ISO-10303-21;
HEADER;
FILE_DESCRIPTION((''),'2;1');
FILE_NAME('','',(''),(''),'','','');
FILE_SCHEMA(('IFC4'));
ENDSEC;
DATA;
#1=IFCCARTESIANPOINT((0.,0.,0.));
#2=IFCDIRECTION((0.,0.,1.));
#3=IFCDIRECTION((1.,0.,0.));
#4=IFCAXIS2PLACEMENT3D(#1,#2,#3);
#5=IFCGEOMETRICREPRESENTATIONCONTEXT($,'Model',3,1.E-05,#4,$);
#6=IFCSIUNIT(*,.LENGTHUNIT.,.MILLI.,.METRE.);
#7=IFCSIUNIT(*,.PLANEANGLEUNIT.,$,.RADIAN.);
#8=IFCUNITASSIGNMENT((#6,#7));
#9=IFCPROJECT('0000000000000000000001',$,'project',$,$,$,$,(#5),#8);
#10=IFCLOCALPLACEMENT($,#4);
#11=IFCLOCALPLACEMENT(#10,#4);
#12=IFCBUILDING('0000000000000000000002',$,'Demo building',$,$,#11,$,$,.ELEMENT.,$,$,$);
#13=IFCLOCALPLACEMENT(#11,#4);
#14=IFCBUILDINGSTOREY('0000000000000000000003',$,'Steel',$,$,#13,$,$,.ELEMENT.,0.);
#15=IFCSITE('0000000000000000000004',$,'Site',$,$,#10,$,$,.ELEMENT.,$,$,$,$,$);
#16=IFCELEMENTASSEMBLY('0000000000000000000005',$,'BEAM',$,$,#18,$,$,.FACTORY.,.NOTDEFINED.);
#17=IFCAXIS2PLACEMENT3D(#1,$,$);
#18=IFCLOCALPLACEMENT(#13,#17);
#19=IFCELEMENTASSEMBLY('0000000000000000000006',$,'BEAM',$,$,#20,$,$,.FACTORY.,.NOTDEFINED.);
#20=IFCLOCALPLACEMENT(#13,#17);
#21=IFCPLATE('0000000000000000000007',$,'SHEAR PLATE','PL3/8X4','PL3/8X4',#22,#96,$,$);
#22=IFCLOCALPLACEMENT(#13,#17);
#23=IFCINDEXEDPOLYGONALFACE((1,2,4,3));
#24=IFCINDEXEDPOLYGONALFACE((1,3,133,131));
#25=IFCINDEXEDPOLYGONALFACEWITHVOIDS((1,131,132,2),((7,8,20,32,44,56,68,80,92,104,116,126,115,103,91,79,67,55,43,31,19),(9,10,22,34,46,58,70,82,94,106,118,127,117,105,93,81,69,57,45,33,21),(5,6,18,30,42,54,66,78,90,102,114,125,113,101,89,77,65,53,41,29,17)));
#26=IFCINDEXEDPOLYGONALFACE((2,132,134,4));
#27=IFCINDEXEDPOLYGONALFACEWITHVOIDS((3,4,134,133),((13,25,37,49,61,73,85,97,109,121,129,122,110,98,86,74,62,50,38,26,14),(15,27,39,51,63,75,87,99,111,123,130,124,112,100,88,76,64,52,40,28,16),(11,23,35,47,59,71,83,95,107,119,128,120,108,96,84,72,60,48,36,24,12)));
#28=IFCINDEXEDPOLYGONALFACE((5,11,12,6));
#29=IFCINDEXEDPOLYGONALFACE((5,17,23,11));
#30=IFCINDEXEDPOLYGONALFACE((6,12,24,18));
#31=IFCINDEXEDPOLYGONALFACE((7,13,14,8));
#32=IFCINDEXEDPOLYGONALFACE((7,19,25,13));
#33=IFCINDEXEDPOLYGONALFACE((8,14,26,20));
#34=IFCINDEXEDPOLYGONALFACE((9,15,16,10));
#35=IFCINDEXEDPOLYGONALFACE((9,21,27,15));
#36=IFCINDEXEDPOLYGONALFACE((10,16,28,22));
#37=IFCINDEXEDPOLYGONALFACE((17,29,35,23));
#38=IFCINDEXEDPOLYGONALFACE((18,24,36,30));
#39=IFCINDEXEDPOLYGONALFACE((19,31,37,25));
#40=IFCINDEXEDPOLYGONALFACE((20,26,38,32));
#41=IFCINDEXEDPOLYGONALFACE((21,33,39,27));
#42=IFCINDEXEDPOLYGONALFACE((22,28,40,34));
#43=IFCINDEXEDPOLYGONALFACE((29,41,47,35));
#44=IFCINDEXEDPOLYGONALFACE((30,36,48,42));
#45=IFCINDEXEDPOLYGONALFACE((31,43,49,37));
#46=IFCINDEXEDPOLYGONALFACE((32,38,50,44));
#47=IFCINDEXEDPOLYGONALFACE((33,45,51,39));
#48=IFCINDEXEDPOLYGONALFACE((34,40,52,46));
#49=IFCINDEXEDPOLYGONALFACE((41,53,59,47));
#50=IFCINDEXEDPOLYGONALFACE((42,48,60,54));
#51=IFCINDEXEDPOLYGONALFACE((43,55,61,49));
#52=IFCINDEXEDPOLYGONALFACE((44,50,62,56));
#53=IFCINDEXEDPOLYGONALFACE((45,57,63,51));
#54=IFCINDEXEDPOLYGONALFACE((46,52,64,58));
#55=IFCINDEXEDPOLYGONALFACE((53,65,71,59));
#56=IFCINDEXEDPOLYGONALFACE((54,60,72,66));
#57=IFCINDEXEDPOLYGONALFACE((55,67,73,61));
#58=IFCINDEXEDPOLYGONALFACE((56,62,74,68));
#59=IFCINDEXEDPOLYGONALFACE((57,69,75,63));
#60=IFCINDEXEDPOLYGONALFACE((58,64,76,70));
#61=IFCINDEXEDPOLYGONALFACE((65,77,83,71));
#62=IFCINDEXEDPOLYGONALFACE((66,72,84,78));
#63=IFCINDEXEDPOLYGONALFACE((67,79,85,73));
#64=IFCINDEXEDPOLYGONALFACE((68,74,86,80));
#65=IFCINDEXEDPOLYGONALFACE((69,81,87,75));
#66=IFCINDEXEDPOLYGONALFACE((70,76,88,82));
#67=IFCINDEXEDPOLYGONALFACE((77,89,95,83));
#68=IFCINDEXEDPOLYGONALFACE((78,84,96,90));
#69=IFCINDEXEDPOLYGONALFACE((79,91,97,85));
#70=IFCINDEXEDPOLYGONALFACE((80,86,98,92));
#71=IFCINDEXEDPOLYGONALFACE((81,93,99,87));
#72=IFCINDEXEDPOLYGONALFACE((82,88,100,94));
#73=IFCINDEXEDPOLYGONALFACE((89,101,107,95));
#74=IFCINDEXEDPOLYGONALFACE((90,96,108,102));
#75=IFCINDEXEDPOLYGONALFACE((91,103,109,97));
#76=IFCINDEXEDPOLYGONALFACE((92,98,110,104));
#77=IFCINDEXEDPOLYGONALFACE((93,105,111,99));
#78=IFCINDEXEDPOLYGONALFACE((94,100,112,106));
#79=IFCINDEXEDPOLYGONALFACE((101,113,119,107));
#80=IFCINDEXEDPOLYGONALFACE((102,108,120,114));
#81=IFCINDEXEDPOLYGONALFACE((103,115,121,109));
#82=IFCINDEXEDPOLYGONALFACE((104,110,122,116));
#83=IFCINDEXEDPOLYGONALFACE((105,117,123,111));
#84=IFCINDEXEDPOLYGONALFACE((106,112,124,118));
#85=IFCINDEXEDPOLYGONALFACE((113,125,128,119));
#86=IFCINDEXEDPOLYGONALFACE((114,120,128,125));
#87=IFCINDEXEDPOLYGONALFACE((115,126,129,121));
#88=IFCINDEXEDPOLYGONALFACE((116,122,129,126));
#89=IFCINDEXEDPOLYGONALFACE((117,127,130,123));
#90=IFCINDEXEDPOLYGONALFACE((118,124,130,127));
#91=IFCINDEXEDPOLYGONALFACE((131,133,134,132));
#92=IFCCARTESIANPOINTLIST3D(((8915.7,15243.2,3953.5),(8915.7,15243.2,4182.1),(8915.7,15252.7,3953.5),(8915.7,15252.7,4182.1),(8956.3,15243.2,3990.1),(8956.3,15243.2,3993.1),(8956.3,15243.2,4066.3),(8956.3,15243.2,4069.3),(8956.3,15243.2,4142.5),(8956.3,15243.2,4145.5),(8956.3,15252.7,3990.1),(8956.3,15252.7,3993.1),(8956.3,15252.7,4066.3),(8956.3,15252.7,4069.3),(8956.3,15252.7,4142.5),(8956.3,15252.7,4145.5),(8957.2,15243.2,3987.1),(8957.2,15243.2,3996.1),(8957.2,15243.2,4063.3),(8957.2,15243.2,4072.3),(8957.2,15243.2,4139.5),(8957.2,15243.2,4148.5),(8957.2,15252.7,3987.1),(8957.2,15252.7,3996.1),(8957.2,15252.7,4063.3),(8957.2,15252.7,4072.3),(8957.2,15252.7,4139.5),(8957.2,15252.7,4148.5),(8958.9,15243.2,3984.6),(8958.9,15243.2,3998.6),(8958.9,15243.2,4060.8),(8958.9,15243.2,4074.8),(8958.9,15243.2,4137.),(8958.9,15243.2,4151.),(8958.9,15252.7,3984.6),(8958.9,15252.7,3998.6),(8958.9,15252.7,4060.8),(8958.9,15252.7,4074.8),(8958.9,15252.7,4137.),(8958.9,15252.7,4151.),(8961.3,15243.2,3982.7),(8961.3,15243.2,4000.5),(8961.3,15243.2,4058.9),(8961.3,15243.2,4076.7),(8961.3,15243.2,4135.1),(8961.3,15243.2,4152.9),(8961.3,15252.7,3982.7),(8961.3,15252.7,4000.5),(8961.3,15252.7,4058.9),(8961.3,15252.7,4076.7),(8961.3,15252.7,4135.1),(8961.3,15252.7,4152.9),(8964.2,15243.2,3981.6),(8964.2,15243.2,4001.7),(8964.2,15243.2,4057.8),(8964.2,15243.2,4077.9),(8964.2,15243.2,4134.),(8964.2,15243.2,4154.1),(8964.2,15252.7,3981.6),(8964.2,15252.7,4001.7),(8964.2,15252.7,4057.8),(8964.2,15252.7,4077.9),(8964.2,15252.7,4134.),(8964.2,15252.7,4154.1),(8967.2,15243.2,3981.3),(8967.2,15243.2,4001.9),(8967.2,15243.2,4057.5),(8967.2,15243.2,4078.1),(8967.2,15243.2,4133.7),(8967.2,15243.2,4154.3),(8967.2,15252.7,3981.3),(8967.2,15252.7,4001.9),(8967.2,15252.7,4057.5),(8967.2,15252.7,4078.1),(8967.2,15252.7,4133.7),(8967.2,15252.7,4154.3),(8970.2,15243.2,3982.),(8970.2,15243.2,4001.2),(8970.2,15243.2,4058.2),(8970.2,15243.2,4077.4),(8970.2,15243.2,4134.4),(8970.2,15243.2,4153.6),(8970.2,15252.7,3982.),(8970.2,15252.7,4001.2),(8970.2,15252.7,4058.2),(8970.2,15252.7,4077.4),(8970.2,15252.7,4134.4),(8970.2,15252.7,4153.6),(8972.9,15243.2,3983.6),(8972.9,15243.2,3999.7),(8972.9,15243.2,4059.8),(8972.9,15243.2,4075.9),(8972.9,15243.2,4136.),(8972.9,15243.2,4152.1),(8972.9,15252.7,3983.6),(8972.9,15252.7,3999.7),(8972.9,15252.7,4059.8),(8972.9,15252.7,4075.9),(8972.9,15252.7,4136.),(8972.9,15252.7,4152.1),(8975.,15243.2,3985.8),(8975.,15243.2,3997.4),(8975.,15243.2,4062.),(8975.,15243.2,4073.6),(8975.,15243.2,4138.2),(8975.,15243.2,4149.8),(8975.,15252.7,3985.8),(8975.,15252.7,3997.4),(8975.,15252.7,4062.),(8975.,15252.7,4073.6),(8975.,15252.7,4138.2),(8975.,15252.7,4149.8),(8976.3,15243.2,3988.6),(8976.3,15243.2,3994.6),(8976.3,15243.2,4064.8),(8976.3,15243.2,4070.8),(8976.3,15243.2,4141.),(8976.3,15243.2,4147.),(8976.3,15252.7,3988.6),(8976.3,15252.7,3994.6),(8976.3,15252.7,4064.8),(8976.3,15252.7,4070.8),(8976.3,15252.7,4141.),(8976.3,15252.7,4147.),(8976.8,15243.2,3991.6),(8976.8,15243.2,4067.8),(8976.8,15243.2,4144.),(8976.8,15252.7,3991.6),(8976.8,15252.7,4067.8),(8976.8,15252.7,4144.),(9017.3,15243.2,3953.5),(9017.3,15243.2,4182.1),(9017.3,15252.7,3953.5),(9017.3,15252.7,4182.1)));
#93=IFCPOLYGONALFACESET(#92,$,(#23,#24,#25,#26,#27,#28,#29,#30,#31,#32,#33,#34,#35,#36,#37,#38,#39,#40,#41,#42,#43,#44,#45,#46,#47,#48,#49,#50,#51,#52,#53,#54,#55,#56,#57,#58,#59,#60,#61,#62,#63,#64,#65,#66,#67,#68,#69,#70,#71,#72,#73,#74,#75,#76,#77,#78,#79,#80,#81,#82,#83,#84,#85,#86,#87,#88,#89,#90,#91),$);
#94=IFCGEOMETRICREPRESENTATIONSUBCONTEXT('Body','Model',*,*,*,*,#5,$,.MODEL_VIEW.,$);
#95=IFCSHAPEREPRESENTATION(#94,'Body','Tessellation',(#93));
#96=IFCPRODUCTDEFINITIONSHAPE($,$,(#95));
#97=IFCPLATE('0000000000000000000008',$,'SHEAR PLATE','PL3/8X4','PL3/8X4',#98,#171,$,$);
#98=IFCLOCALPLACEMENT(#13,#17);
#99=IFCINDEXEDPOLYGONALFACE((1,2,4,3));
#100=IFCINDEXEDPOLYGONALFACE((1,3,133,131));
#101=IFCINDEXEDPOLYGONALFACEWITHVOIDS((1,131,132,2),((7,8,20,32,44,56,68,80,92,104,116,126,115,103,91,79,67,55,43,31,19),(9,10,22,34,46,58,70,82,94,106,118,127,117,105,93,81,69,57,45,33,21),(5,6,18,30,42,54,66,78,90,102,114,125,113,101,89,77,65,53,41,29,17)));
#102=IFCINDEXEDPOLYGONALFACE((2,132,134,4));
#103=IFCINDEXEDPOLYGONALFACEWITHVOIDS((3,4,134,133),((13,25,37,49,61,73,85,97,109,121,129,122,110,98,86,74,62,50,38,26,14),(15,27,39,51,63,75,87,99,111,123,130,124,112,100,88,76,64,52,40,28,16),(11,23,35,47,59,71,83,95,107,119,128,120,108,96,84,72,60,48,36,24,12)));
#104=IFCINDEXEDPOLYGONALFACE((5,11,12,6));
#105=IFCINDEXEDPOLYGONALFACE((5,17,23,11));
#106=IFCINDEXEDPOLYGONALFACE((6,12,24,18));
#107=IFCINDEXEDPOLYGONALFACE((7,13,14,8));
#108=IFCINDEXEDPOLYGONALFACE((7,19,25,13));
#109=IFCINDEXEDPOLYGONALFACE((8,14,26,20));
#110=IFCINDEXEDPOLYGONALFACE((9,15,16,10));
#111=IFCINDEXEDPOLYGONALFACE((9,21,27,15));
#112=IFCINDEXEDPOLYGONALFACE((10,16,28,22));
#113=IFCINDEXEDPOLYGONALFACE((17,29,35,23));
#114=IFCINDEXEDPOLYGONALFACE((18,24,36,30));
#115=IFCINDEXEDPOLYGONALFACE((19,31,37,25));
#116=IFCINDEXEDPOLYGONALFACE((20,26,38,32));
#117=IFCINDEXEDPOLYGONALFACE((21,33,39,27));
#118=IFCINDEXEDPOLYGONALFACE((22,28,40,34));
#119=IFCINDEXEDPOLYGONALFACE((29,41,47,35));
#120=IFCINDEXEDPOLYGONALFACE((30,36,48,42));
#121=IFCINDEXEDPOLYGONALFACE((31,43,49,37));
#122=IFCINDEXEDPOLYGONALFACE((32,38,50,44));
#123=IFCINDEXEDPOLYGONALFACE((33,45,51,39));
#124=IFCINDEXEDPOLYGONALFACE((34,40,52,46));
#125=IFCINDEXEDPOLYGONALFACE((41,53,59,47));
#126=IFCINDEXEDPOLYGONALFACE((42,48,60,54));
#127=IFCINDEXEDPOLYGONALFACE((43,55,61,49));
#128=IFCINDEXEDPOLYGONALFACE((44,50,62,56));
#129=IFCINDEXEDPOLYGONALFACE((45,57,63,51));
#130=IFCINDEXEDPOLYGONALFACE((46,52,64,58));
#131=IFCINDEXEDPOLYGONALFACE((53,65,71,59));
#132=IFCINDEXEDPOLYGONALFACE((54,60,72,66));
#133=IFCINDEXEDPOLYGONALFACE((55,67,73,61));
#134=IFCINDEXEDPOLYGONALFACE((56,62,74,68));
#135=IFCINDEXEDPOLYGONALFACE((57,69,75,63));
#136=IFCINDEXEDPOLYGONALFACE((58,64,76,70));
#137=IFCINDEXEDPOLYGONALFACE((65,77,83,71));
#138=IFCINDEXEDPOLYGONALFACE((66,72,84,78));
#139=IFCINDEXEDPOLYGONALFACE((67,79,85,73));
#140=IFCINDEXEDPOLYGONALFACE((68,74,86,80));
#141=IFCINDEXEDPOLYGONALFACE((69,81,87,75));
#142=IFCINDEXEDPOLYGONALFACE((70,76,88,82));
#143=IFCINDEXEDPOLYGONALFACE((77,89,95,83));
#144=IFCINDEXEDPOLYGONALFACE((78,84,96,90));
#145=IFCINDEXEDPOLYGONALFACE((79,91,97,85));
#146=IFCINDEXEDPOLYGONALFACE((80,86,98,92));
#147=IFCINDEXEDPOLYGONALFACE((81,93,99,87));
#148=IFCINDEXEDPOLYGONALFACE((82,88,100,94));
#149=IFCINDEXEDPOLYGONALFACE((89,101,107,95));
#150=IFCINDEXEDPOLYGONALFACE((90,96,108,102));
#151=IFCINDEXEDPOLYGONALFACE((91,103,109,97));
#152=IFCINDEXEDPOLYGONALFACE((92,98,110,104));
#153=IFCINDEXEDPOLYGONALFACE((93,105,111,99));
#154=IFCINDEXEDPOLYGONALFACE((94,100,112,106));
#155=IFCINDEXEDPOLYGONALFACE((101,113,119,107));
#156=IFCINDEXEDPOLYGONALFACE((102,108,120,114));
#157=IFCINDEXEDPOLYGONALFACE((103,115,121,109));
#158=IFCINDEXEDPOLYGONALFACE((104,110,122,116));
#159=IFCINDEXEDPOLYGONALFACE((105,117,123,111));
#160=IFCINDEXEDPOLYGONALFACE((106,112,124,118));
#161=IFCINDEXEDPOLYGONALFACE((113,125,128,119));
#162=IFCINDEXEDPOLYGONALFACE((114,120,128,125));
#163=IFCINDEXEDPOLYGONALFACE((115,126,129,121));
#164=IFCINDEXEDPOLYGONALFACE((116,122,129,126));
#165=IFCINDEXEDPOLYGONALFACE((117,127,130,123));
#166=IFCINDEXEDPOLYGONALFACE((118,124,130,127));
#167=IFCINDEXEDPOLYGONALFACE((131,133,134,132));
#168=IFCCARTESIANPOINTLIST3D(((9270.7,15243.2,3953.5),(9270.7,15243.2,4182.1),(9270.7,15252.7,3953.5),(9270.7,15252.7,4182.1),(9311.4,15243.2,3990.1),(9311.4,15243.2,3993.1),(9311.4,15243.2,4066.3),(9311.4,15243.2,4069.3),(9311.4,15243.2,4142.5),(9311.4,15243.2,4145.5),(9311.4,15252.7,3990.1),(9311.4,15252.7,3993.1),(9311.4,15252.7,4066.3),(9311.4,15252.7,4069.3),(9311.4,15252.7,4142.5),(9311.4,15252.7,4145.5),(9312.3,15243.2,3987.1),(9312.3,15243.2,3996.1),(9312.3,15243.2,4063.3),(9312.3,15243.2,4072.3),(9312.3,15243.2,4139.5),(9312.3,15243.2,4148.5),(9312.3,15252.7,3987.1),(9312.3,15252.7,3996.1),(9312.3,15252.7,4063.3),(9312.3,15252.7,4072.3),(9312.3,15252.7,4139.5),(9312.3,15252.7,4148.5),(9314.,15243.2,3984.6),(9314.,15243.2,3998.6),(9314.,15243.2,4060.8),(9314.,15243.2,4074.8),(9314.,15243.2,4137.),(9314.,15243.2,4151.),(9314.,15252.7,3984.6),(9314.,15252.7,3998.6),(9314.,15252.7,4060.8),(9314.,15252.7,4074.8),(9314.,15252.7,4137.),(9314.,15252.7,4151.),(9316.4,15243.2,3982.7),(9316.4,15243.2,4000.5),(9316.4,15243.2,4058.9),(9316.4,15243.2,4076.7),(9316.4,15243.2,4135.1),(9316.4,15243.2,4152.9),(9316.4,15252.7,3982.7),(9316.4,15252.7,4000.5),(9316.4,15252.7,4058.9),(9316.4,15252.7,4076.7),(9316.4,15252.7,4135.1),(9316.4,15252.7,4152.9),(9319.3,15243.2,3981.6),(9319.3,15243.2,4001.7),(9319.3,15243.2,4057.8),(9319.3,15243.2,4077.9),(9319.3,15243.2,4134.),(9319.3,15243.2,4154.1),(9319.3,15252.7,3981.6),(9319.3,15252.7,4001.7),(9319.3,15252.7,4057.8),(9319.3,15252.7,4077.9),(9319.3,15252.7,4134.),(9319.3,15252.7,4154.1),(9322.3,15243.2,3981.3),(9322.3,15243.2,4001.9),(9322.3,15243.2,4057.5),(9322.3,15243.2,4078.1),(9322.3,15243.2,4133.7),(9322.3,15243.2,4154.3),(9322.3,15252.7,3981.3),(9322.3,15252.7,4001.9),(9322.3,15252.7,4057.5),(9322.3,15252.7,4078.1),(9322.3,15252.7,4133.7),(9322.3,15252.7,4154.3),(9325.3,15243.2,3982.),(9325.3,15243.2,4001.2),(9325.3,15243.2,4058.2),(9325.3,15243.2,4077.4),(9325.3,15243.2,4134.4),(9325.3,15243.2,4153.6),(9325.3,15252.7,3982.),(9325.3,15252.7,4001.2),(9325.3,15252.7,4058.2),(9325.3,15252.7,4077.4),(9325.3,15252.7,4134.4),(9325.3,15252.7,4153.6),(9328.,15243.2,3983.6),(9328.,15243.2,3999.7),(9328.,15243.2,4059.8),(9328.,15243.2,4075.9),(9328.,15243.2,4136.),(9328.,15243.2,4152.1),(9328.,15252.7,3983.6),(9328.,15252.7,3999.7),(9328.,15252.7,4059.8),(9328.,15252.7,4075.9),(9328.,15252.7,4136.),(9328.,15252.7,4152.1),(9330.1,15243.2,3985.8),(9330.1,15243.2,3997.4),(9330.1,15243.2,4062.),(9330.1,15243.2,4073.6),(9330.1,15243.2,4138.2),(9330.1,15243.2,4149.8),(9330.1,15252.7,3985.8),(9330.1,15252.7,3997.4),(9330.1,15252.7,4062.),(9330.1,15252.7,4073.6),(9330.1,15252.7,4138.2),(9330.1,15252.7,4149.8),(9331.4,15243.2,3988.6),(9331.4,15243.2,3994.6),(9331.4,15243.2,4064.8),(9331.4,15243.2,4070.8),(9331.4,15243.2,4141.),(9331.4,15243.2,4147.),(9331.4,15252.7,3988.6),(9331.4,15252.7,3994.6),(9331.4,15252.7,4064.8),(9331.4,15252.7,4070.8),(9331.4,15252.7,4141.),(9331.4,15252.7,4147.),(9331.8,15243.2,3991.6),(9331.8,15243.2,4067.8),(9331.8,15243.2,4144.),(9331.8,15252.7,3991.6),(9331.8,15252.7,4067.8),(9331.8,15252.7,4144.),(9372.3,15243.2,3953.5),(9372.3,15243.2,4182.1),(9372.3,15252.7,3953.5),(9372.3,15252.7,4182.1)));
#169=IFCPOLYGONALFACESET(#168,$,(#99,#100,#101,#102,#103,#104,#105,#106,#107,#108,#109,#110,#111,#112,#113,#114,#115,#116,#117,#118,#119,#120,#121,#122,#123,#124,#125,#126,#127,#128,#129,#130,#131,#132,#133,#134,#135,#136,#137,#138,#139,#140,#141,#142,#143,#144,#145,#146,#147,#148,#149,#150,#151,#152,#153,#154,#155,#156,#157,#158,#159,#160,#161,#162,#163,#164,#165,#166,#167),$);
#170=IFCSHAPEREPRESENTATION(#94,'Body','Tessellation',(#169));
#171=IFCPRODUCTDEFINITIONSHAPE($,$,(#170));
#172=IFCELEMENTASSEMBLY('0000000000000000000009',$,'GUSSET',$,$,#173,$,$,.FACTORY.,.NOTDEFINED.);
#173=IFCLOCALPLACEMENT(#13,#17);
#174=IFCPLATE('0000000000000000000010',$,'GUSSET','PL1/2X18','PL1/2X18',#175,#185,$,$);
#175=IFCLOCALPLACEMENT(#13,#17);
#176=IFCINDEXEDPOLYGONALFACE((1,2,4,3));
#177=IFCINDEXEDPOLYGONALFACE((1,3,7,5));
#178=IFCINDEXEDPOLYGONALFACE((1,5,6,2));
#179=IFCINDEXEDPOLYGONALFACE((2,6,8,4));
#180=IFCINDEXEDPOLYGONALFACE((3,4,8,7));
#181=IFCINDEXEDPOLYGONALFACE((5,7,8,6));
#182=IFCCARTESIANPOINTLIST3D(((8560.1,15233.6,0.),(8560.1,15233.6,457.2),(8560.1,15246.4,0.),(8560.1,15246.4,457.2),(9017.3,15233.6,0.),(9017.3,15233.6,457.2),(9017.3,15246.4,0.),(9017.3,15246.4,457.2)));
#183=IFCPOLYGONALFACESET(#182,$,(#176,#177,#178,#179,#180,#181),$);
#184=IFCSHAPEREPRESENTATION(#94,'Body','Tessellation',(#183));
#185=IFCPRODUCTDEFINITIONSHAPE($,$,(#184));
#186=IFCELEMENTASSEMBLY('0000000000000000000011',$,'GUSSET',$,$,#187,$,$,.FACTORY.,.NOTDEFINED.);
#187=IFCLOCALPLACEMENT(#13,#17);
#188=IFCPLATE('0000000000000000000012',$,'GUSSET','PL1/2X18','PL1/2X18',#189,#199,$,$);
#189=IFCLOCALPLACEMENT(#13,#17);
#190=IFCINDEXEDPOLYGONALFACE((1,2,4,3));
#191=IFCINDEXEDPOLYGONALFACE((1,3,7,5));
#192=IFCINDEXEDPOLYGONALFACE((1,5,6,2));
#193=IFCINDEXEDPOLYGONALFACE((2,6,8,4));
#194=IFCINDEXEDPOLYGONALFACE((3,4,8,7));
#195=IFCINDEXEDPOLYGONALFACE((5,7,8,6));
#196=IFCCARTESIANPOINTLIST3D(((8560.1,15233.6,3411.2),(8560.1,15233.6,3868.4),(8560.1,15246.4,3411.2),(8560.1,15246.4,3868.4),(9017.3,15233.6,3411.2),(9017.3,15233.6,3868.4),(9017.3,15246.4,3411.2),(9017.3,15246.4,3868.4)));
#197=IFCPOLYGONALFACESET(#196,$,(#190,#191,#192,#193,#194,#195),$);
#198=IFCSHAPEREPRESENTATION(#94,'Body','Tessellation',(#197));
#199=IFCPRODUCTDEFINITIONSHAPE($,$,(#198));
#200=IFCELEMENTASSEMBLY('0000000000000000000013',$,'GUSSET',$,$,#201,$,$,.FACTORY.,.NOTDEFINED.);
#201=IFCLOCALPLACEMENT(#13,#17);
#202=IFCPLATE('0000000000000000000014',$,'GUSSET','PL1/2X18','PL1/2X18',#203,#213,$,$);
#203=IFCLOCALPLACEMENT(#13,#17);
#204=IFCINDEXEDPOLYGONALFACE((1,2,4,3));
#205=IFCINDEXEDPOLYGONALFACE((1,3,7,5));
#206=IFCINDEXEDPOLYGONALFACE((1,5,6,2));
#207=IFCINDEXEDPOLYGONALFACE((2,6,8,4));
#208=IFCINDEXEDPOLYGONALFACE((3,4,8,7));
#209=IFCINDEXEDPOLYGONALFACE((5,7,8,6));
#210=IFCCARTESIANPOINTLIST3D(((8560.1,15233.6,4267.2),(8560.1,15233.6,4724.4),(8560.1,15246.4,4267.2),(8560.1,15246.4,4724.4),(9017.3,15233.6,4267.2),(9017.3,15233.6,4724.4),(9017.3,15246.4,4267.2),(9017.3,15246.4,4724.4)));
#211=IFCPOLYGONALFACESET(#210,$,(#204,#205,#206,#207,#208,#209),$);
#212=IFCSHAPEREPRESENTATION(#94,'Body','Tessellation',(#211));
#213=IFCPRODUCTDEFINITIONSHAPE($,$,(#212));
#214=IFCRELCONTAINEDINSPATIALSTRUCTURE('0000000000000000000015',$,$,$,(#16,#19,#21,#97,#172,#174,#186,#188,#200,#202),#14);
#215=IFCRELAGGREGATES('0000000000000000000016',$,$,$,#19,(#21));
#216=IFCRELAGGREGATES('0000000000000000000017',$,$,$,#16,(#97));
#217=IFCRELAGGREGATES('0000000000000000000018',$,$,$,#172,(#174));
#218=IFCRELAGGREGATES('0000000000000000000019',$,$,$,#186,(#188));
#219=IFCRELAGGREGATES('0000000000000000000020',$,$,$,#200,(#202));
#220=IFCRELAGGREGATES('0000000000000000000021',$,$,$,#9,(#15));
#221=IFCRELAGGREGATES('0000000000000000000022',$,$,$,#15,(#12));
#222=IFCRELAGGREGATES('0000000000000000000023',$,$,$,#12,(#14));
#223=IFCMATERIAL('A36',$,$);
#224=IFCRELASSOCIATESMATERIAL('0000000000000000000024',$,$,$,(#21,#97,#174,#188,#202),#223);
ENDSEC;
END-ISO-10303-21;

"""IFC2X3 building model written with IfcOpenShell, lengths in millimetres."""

from ifc_helpers import new_model, si_unit, frame, frame_2d, origin, origin_with_axes, place, context, subcontext, project, spatial, rectangle, circle, extrude, boolean, material, element, aggregate, save


model = new_model("IFC2X3")

# Units and contexts
model_context = context("Model", 3, precision=1e-05, world=origin_with_axes())
body_context = subcontext(model_context, "Body", "Model", "MODEL_VIEW")
ifc_project = project(units=[si_unit("LENGTHUNIT", "METRE", prefix="MILLI"), si_unit("PLANEANGLEUNIT", "RADIAN")], contexts=[model_context])

# Site, building, storey
site_placement = place(None, origin_with_axes())
site = spatial("IfcSite", under=ifc_project, at=site_placement, Name="Site", CompositionType="ELEMENT")
building_placement = place(site_placement, origin_with_axes())
building = spatial("IfcBuilding", under=site, at=building_placement, Name="Demo building", CompositionType="ELEMENT")
placement = place(building_placement, origin_with_axes())
storey = spatial("IfcBuildingStorey", under=building, at=placement, Name="Steel", CompositionType="ELEMENT", Elevation=0.0)

# Element assembly
assembly_1 = element("IfcElementAssembly", 1, at=placement, inside=storey, Name="BEAM", AssemblyPlace="FACTORY", PredefinedType="NOTDEFINED")

# Shared definitions
ifc_material_1 = material(Name="A36")

# Element assembly, plate
assembly_2 = element("IfcElementAssembly", 2, at=placement, inside=storey, Name="BEAM", AssemblyPlace="FACTORY", PredefinedType="NOTDEFINED")
plate_1_placement = place(placement, frame((8915.7, 15252.7, 3953.5), z_axis=(0.0, -1.0, 0.0), x_axis=(1.0, 0.0, 0.0)))
plate_1 = element("IfcPlate", 3, at=plate_1_placement, inside=storey, material=ifc_material_1, Name="SHEAR PLATE", Description="PL3/8X4", ObjectType="PL3/8X4", context=body_context, shape_type="CSG", body=[
    boolean("DIFFERENCE", boolean("DIFFERENCE", boolean("DIFFERENCE", extrude(rectangle(XDim=101.6, YDim=228.6, at=frame_2d((50.8, 114.3))), origin(), (0.0, 0.0, 1.0), 9.5), extrude(circle(Radius=10.3, at=frame_2d((50.8, 38.1))), frame((0.0, 0.0, -5.0)), (0.0, 0.0, 1.0), 19.5)), extrude(circle(Radius=10.3, at=frame_2d((50.8, 114.3))), frame((0.0, 0.0, -5.0)), (0.0, 0.0, 1.0), 19.5)), extrude(circle(Radius=10.3, at=frame_2d((50.8, 190.5))), frame((0.0, 0.0, -5.0)), (0.0, 0.0, 1.0), 19.5)),
])
aggregate(assembly_2, [plate_1])

# Plate
plate_2_placement = place(placement, frame((9270.7, 15252.7, 3953.5), z_axis=(0.0, -1.0, 0.0), x_axis=(1.0, 0.0, 0.0)))
plate_2 = element("IfcPlate", 4, at=plate_2_placement, inside=storey, material=ifc_material_1, Name="SHEAR PLATE", Description="PL3/8X4", ObjectType="PL3/8X4", context=body_context, shape_type="CSG", body=[
    boolean("DIFFERENCE", boolean("DIFFERENCE", boolean("DIFFERENCE", extrude(rectangle(XDim=101.6, YDim=228.6, at=frame_2d((50.8, 114.3))), origin(), (0.0, 0.0, 1.0), 9.5), extrude(circle(Radius=10.3, at=frame_2d((50.8, 38.1))), frame((0.0, 0.0, -5.0)), (0.0, 0.0, 1.0), 19.5)), extrude(circle(Radius=10.3, at=frame_2d((50.8, 114.3))), frame((0.0, 0.0, -5.0)), (0.0, 0.0, 1.0), 19.5)), extrude(circle(Radius=10.3, at=frame_2d((50.8, 190.5))), frame((0.0, 0.0, -5.0)), (0.0, 0.0, 1.0), 19.5)),
])
aggregate(assembly_1, [plate_2])

# Element assemblies, plates
assembly_3 = element("IfcElementAssembly", 5, at=placement, inside=storey, Name="GUSSET", AssemblyPlace="FACTORY", PredefinedType="NOTDEFINED")
plate_3_placement = place(placement, frame((8560.1, 15246.4, 0.0), z_axis=(0.0, -1.0, 0.0), x_axis=(1.0, 0.0, 0.0)))
plate_3 = element("IfcPlate", 6, at=plate_3_placement, inside=storey, material=ifc_material_1, Name="GUSSET", Description="PL1/2X18", ObjectType="PL1/2X18", context=body_context, shape_type="SweptSolid", body=[
    extrude(rectangle(XDim=457.2, YDim=457.2, at=frame_2d((228.6, 228.6))), origin(), (0.0, 0.0, 1.0), 12.7),
])
aggregate(assembly_3, [plate_3])
assembly_4 = element("IfcElementAssembly", 7, at=placement, inside=storey, Name="GUSSET", AssemblyPlace="FACTORY", PredefinedType="NOTDEFINED")
plate_4_placement = place(placement, frame((8560.1, 15246.4, 3411.2), z_axis=(0.0, -1.0, 0.0), x_axis=(1.0, 0.0, 0.0)))
plate_4 = element("IfcPlate", 8, at=plate_4_placement, inside=storey, material=ifc_material_1, Name="GUSSET", Description="PL1/2X18", ObjectType="PL1/2X18", context=body_context, shape_type="SweptSolid", body=[
    extrude(rectangle(XDim=457.2, YDim=457.2, at=frame_2d((228.6, 228.6))), origin(), (0.0, 0.0, 1.0), 12.7),
])
aggregate(assembly_4, [plate_4])
assembly_5 = element("IfcElementAssembly", 9, at=placement, inside=storey, Name="GUSSET", AssemblyPlace="FACTORY", PredefinedType="NOTDEFINED")
plate_5_placement = place(placement, frame((8560.1, 15246.4, 4267.2), z_axis=(0.0, -1.0, 0.0), x_axis=(1.0, 0.0, 0.0)))
plate_5 = element("IfcPlate", 10, at=plate_5_placement, inside=storey, material=ifc_material_1, Name="GUSSET", Description="PL1/2X18", ObjectType="PL1/2X18", context=body_context, shape_type="SweptSolid", body=[
    extrude(rectangle(XDim=457.2, YDim=457.2, at=frame_2d((228.6, 228.6))), origin(), (0.0, 0.0, 1.0), 12.7),
])
aggregate(assembly_5, [plate_5])

save(model, "model.ifc")
